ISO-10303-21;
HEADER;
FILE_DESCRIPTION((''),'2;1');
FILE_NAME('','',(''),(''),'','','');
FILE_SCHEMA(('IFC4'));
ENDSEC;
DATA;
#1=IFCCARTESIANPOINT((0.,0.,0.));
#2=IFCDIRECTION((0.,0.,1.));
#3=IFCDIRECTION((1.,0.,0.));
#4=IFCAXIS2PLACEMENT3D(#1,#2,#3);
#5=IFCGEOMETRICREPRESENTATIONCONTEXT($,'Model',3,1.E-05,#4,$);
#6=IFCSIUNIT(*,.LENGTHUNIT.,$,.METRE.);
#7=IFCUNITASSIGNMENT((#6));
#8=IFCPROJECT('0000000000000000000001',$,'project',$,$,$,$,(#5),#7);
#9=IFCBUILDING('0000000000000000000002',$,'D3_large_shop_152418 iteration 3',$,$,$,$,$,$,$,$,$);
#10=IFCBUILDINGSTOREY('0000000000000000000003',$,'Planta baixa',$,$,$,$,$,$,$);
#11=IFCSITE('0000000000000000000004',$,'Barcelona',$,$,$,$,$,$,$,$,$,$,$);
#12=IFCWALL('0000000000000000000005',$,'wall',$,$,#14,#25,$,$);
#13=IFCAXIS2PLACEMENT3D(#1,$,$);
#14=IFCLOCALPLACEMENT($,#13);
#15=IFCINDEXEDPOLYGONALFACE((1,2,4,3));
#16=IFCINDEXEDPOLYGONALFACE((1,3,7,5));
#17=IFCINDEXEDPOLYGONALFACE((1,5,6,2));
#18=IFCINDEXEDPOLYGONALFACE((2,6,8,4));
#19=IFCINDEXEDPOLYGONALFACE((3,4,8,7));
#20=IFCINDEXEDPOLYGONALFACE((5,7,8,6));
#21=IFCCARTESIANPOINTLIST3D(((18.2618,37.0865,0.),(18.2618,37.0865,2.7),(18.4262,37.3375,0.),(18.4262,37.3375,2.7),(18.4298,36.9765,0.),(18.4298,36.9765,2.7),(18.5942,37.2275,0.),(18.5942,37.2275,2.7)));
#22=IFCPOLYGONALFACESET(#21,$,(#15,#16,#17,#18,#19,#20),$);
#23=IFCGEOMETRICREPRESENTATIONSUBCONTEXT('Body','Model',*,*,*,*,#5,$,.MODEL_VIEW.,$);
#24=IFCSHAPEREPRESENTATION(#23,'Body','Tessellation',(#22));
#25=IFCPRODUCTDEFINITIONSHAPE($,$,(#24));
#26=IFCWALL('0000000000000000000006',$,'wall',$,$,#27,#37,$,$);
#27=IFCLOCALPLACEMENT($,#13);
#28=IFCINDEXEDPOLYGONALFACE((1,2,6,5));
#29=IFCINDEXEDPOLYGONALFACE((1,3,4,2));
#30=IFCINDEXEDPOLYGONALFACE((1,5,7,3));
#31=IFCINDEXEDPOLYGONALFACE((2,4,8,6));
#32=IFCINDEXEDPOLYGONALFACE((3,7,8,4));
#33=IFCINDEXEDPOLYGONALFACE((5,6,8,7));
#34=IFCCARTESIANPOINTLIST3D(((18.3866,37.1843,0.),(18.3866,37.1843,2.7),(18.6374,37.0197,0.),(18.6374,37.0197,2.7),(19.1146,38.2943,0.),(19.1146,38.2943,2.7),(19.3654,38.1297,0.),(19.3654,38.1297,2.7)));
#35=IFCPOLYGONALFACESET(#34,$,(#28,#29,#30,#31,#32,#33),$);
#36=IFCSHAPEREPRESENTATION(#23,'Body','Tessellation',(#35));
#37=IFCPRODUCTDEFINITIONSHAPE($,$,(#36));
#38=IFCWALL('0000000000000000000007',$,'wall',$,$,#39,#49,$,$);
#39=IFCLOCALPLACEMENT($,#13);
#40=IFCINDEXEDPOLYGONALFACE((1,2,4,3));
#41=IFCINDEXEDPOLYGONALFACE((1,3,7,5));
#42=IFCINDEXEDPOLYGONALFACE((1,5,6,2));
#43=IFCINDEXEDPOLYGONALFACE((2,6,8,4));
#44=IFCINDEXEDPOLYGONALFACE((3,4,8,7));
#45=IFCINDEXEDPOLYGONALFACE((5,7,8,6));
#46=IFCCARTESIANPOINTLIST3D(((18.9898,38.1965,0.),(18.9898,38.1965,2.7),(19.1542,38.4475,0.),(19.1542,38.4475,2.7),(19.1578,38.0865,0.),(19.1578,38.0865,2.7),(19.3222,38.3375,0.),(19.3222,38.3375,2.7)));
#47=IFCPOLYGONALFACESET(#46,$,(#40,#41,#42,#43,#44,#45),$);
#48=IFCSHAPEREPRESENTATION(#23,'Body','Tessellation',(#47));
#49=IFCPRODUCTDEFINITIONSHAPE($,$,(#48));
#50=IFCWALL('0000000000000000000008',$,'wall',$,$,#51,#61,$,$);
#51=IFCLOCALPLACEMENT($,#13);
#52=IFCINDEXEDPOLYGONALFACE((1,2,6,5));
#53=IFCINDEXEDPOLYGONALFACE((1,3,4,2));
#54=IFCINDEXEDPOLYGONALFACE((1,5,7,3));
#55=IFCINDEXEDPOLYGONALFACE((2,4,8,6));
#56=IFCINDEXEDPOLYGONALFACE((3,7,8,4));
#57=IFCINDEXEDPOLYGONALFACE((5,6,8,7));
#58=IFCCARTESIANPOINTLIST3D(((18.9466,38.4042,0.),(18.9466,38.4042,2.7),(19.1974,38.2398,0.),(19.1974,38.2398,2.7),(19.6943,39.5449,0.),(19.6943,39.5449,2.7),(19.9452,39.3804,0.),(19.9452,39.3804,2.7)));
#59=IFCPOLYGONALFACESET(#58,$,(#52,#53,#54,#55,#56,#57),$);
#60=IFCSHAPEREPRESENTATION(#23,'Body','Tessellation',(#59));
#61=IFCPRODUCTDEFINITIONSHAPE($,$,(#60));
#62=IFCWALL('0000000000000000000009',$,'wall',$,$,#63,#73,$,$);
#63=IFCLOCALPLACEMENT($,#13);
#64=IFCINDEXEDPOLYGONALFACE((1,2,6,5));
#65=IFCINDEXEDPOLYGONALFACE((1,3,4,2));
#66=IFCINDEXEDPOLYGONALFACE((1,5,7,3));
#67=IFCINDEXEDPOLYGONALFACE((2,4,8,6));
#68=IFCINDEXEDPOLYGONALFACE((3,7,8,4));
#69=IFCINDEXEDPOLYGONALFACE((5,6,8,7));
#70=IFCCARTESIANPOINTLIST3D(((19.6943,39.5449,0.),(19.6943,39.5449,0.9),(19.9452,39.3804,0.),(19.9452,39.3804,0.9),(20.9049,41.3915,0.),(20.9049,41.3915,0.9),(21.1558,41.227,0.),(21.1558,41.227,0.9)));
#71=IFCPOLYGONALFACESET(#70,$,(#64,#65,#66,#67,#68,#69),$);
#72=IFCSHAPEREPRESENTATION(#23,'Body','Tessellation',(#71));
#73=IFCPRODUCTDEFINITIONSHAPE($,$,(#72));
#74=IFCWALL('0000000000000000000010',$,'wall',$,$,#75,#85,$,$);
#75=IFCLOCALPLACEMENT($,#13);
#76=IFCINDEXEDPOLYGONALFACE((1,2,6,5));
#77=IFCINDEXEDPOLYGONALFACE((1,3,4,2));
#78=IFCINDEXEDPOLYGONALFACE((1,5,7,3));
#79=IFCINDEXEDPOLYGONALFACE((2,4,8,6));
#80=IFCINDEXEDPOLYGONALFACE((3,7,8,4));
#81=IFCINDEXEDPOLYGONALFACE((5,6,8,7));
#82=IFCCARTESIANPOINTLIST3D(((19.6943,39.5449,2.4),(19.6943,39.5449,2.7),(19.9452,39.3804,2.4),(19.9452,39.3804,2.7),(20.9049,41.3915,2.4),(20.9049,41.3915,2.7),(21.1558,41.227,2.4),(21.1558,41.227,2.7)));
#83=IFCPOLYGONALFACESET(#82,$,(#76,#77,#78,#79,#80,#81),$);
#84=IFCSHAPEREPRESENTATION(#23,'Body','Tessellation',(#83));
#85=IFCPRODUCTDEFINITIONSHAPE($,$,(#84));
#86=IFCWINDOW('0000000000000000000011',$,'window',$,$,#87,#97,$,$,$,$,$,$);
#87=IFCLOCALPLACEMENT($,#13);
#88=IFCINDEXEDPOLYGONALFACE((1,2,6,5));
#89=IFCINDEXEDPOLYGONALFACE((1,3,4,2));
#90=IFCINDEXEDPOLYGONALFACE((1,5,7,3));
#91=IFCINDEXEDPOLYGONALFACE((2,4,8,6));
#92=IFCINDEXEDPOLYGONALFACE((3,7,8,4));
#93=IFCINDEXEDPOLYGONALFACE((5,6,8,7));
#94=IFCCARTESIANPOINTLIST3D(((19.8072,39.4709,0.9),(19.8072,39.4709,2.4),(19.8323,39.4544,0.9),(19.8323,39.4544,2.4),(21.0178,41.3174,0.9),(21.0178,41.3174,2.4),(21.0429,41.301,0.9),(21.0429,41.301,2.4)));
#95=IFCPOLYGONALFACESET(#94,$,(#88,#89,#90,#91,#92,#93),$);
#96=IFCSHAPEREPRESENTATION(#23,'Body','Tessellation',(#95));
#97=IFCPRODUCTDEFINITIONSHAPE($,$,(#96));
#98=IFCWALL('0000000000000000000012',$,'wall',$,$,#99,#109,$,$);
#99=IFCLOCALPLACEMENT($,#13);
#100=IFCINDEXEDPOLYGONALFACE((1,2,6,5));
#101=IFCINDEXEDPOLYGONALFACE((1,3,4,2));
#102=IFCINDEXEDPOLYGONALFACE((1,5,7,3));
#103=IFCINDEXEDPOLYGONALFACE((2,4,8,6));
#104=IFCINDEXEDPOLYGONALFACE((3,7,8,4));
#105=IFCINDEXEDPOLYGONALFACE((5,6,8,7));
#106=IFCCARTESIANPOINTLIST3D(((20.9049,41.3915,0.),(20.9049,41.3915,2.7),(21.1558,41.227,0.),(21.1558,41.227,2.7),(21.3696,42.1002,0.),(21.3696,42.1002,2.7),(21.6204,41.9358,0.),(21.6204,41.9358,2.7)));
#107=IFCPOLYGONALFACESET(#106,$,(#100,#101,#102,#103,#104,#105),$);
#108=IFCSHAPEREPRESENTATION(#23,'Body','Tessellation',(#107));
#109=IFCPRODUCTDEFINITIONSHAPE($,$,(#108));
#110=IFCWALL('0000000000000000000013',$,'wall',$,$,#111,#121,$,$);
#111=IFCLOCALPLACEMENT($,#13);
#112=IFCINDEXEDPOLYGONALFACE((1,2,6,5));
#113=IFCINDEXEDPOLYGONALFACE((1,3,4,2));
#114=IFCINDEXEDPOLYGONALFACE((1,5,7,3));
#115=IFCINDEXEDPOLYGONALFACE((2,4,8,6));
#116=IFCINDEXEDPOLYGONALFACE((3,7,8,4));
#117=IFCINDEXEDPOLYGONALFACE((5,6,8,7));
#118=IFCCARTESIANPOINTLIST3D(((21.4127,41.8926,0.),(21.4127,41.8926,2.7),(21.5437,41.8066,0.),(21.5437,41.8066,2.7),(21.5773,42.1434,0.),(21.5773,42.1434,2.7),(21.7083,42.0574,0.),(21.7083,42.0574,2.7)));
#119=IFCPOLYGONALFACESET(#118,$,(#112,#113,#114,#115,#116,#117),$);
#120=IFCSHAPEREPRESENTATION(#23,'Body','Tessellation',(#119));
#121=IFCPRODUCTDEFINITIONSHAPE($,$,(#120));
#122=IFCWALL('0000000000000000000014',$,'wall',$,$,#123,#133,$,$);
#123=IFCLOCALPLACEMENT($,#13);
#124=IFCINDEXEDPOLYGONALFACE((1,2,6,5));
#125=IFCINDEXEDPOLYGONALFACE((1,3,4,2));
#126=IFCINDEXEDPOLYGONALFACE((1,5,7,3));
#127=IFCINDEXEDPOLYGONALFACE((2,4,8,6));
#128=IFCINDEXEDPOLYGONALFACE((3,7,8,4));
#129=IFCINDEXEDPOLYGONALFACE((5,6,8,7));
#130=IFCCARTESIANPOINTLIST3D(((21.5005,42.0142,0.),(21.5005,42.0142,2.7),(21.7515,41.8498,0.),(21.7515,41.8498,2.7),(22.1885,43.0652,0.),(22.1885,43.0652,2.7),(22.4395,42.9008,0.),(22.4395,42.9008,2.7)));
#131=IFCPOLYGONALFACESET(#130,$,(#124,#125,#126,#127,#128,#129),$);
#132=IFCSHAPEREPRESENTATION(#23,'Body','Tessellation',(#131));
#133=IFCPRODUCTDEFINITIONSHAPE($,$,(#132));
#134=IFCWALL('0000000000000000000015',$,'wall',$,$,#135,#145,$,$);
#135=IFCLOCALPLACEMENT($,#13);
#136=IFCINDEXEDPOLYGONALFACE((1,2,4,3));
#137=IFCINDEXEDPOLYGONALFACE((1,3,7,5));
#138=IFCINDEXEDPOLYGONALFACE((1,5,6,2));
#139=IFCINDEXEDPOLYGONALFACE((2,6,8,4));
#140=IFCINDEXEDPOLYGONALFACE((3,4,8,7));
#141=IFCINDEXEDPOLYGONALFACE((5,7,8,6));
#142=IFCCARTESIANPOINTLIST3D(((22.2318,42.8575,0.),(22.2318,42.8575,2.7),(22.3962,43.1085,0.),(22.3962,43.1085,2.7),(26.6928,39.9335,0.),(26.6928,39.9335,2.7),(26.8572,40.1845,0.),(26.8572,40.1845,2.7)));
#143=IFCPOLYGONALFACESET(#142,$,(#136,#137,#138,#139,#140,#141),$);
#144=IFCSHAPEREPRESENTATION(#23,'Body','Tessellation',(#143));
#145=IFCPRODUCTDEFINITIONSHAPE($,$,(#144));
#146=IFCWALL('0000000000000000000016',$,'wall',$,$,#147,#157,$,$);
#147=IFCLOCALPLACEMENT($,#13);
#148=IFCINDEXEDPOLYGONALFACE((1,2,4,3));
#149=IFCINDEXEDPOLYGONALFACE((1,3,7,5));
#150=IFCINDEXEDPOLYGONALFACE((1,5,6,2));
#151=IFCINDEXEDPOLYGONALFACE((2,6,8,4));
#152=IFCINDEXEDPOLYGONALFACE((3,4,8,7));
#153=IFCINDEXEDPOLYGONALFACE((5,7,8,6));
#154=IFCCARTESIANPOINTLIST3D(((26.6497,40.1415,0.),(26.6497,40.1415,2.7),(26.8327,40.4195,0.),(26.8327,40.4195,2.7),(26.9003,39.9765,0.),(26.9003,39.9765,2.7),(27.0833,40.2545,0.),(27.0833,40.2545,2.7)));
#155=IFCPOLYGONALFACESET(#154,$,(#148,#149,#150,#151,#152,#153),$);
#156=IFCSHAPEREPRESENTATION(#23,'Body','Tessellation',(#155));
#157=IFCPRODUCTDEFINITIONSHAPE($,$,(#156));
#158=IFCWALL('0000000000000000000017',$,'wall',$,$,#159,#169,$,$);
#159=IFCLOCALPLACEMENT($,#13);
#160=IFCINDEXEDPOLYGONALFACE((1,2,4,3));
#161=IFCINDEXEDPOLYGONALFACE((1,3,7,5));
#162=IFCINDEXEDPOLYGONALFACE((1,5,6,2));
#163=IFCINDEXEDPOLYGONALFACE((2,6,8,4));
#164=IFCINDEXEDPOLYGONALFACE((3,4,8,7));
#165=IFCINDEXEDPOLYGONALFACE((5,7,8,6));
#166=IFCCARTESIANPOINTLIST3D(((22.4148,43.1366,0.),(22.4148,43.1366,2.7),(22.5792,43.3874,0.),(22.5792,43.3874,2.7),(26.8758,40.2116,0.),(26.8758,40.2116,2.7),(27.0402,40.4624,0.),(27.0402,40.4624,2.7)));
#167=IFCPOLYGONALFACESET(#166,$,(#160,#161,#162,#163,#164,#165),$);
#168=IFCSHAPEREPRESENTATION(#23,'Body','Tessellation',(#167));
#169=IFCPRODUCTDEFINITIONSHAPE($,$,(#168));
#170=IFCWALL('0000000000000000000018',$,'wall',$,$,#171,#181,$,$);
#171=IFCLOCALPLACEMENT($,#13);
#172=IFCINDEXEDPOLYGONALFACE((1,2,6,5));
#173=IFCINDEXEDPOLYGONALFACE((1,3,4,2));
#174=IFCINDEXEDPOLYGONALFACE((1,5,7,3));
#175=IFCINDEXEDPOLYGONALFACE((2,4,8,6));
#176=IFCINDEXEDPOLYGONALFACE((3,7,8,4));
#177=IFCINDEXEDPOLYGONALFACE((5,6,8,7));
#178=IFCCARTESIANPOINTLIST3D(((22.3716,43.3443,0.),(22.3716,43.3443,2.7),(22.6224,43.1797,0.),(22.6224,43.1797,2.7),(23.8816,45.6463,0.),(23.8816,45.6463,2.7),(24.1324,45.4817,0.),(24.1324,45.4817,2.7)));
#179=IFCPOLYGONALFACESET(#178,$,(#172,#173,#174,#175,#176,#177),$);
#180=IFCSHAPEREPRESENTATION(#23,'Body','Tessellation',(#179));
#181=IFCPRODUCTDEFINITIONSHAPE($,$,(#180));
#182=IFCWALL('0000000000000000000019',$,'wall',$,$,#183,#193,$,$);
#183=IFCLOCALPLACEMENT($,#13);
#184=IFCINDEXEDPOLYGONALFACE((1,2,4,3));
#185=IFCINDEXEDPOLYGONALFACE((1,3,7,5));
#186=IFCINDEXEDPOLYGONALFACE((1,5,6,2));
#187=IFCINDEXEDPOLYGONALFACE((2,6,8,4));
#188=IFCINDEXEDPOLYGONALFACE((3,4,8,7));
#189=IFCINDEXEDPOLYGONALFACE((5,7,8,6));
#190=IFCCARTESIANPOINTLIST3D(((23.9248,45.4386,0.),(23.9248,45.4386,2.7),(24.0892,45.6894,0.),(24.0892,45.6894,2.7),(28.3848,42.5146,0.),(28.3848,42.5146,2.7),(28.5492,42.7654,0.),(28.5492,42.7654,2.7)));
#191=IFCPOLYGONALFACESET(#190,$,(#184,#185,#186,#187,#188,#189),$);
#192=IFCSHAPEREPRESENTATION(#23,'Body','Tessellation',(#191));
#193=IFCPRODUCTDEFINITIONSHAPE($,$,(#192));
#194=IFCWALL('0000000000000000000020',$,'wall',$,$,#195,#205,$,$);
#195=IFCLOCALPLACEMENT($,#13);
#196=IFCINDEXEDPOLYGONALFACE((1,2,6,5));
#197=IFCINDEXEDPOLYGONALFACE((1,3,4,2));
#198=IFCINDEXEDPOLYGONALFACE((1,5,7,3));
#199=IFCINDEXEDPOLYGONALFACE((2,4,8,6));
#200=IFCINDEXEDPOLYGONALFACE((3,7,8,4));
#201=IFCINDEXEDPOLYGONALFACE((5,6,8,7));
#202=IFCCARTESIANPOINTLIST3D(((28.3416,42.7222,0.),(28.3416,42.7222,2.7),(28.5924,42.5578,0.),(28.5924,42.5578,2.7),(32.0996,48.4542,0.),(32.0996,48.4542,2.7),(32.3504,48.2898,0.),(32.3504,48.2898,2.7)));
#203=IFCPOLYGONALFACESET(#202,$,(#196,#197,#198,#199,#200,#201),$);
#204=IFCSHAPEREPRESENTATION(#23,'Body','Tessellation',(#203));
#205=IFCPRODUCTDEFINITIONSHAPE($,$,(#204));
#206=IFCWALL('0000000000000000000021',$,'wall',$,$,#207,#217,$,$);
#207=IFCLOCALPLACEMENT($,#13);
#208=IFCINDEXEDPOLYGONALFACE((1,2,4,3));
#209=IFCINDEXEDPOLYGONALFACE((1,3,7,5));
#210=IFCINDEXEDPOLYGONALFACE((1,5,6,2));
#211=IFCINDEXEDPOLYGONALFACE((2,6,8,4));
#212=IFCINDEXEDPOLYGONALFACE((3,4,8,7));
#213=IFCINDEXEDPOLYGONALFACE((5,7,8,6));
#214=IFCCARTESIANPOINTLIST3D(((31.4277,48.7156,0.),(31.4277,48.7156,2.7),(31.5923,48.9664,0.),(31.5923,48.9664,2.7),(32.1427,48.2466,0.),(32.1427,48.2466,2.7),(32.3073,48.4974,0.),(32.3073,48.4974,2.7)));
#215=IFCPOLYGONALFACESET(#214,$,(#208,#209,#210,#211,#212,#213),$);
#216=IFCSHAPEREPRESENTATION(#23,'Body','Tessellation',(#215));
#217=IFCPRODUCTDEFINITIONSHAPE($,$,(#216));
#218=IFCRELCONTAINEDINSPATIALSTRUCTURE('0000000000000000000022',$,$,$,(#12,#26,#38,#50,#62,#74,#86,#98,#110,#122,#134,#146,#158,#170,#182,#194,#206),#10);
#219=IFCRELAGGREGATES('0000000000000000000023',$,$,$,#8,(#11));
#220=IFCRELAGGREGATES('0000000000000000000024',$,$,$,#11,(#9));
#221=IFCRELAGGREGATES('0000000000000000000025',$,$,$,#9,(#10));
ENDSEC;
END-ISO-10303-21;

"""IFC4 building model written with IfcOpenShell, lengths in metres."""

from ifc_helpers import new_model, si_unit, frame, origin, origin_with_axes, place, context, subcontext, project, spatial, polyline, outline, extrude, element, save


model = new_model("IFC4")

# Units and contexts
model_context = context("Model", 3, precision=1e-05, world=origin_with_axes())
body_context = subcontext(model_context, "Body", "Model", "MODEL_VIEW")
ifc_project = project(units=[si_unit("LENGTHUNIT", "METRE")], contexts=[model_context])

# Site, building, storey
site = spatial("IfcSite", under=ifc_project, Name="Barcelona")
building = spatial("IfcBuilding", under=site, Name="D3_large_shop_152418 iteration 3")
storey = spatial("IfcBuildingStorey", under=building, Name="Planta baixa")

# Walls
wall_1_placement = place(None, origin_with_axes())
element("IfcWall", 1, at=wall_1_placement, inside=storey, Name="wall", context=body_context, shape_type="SweptSolid", body=[
    extrude(outline(polyline([(18.4262, 37.3375), (18.5942, 37.2275), (18.4298, 36.9765), (18.2618, 37.0865), (18.4262, 37.3375)])), origin(), (0.0, 0.0, 1.0), 2.7),
])
wall_2_placement = place(None, origin_with_axes())
element("IfcWall", 2, at=wall_2_placement, inside=storey, Name="wall", context=body_context, shape_type="SweptSolid", body=[
    extrude(outline(polyline([(18.3866, 37.1843), (19.1146, 38.2943), (19.3654, 38.1297), (18.6374, 37.0197), (18.3866, 37.1843)])), origin(), (0.0, 0.0, 1.0), 2.7),
])
wall_3_placement = place(None, origin_with_axes())
element("IfcWall", 3, at=wall_3_placement, inside=storey, Name="wall", context=body_context, shape_type="SweptSolid", body=[
    extrude(outline(polyline([(19.1578, 38.0865), (18.9898, 38.1965), (19.1542, 38.4475), (19.3222, 38.3375), (19.1578, 38.0865)])), origin(), (0.0, 0.0, 1.0), 2.7),
])
wall_4_placement = place(None, origin_with_axes())
element("IfcWall", 4, at=wall_4_placement, inside=storey, Name="wall", context=body_context, shape_type="SweptSolid", body=[
    extrude(outline(polyline([(18.9466, 38.4042), (19.6943, 39.5449), (19.9452, 39.3804), (19.1974, 38.2398), (18.9466, 38.4042)])), origin(), (0.0, 0.0, 1.0), 2.7),
])
wall_5_placement = place(None, origin_with_axes())
element("IfcWall", 5, at=wall_5_placement, inside=storey, Name="wall", context=body_context, shape_type="SweptSolid", body=[
    extrude(outline(polyline([(19.6943, 39.5449), (20.9049, 41.3915), (21.1558, 41.227), (19.9452, 39.3804), (19.6943, 39.5449)])), origin(), (0.0, 0.0, 1.0), 0.9),
])
wall_6_placement = place(None, origin_with_axes())
element("IfcWall", 6, at=wall_6_placement, inside=storey, Name="wall", context=body_context, shape_type="SweptSolid", body=[
    extrude(outline(polyline([(19.6943, 39.5449), (20.9049, 41.3915), (21.1558, 41.227), (19.9452, 39.3804), (19.6943, 39.5449)])), frame((0.0, 0.0, 2.4)), (0.0, 0.0, 1.0), 0.3),
])

# Window
window_1_placement = place(None, origin_with_axes())
element("IfcWindow", 7, at=window_1_placement, inside=storey, Name="window", context=body_context, shape_type="SweptSolid", body=[
    extrude(outline(polyline([(19.8072, 39.4709), (21.0178, 41.3174), (21.0429, 41.301), (19.8323, 39.4544), (19.8072, 39.4709)])), frame((0.0, 0.0, 0.9)), (0.0, 0.0, 1.0), 1.5),
])

# Walls
wall_7_placement = place(None, origin_with_axes())
element("IfcWall", 8, at=wall_7_placement, inside=storey, Name="wall", context=body_context, shape_type="SweptSolid", body=[
    extrude(outline(polyline([(20.9049, 41.3915), (21.3696, 42.1002), (21.6204, 41.9358), (21.1558, 41.227), (20.9049, 41.3915)])), origin(), (0.0, 0.0, 1.0), 2.7),
])
wall_8_placement = place(None, origin_with_axes())
element("IfcWall", 9, at=wall_8_placement, inside=storey, Name="wall", context=body_context, shape_type="SweptSolid", body=[
    extrude(outline(polyline([(21.5773, 42.1434), (21.7083, 42.0574), (21.5437, 41.8066), (21.4127, 41.8926), (21.5773, 42.1434)])), origin(), (0.0, 0.0, 1.0), 2.7),
])
wall_9_placement = place(None, origin_with_axes())
element("IfcWall", 10, at=wall_9_placement, inside=storey, Name="wall", context=body_context, shape_type="SweptSolid", body=[
    extrude(outline(polyline([(21.5005, 42.0142), (22.1885, 43.0652), (22.4395, 42.9008), (21.7515, 41.8498), (21.5005, 42.0142)])), origin(), (0.0, 0.0, 1.0), 2.7),
])
wall_10_placement = place(None, origin_with_axes())
element("IfcWall", 11, at=wall_10_placement, inside=storey, Name="wall", context=body_context, shape_type="SweptSolid", body=[
    extrude(outline(polyline([(22.3962, 43.1085), (26.8572, 40.1845), (26.6928, 39.9335), (22.2318, 42.8575), (22.3962, 43.1085)])), origin(), (0.0, 0.0, 1.0), 2.7),
])
wall_11_placement = place(None, origin_with_axes())
element("IfcWall", 12, at=wall_11_placement, inside=storey, Name="wall", context=body_context, shape_type="SweptSolid", body=[
    extrude(outline(polyline([(26.6497, 40.1415), (26.8327, 40.4195), (27.0833, 40.2545), (26.9003, 39.9765), (26.6497, 40.1415)])), origin(), (0.0, 0.0, 1.0), 2.7),
])
wall_12_placement = place(None, origin_with_axes())
element("IfcWall", 13, at=wall_12_placement, inside=storey, Name="wall", context=body_context, shape_type="SweptSolid", body=[
    extrude(outline(polyline([(26.8758, 40.2116), (22.4148, 43.1366), (22.5792, 43.3874), (27.0402, 40.4624), (26.8758, 40.2116)])), origin(), (0.0, 0.0, 1.0), 2.7),
])
wall_13_placement = place(None, origin_with_axes())
element("IfcWall", 14, at=wall_13_placement, inside=storey, Name="wall", context=body_context, shape_type="SweptSolid", body=[
    extrude(outline(polyline([(22.3716, 43.3443), (23.8816, 45.6463), (24.1324, 45.4817), (22.6224, 43.1797), (22.3716, 43.3443)])), origin(), (0.0, 0.0, 1.0), 2.7),
])
wall_14_placement = place(None, origin_with_axes())
element("IfcWall", 15, at=wall_14_placement, inside=storey, Name="wall", context=body_context, shape_type="SweptSolid", body=[
    extrude(outline(polyline([(24.0892, 45.6894), (28.5492, 42.7654), (28.3848, 42.5146), (23.9248, 45.4386), (24.0892, 45.6894)])), origin(), (0.0, 0.0, 1.0), 2.7),
])
wall_15_placement = place(None, origin_with_axes())
element("IfcWall", 16, at=wall_15_placement, inside=storey, Name="wall", context=body_context, shape_type="SweptSolid", body=[
    extrude(outline(polyline([(28.3416, 42.7222), (32.0996, 48.4542), (32.3504, 48.2898), (28.5924, 42.5578), (28.3416, 42.7222)])), origin(), (0.0, 0.0, 1.0), 2.7),
])
wall_16_placement = place(None, origin_with_axes())
element("IfcWall", 17, at=wall_16_placement, inside=storey, Name="wall", context=body_context, shape_type="SweptSolid", body=[
    extrude(outline(polyline([(32.1427, 48.2466), (31.4277, 48.7156), (31.5923, 48.9664), (32.3073, 48.4974), (32.1427, 48.2466)])), origin(), (0.0, 0.0, 1.0), 2.7),
])

save(model, "model.ifc")
